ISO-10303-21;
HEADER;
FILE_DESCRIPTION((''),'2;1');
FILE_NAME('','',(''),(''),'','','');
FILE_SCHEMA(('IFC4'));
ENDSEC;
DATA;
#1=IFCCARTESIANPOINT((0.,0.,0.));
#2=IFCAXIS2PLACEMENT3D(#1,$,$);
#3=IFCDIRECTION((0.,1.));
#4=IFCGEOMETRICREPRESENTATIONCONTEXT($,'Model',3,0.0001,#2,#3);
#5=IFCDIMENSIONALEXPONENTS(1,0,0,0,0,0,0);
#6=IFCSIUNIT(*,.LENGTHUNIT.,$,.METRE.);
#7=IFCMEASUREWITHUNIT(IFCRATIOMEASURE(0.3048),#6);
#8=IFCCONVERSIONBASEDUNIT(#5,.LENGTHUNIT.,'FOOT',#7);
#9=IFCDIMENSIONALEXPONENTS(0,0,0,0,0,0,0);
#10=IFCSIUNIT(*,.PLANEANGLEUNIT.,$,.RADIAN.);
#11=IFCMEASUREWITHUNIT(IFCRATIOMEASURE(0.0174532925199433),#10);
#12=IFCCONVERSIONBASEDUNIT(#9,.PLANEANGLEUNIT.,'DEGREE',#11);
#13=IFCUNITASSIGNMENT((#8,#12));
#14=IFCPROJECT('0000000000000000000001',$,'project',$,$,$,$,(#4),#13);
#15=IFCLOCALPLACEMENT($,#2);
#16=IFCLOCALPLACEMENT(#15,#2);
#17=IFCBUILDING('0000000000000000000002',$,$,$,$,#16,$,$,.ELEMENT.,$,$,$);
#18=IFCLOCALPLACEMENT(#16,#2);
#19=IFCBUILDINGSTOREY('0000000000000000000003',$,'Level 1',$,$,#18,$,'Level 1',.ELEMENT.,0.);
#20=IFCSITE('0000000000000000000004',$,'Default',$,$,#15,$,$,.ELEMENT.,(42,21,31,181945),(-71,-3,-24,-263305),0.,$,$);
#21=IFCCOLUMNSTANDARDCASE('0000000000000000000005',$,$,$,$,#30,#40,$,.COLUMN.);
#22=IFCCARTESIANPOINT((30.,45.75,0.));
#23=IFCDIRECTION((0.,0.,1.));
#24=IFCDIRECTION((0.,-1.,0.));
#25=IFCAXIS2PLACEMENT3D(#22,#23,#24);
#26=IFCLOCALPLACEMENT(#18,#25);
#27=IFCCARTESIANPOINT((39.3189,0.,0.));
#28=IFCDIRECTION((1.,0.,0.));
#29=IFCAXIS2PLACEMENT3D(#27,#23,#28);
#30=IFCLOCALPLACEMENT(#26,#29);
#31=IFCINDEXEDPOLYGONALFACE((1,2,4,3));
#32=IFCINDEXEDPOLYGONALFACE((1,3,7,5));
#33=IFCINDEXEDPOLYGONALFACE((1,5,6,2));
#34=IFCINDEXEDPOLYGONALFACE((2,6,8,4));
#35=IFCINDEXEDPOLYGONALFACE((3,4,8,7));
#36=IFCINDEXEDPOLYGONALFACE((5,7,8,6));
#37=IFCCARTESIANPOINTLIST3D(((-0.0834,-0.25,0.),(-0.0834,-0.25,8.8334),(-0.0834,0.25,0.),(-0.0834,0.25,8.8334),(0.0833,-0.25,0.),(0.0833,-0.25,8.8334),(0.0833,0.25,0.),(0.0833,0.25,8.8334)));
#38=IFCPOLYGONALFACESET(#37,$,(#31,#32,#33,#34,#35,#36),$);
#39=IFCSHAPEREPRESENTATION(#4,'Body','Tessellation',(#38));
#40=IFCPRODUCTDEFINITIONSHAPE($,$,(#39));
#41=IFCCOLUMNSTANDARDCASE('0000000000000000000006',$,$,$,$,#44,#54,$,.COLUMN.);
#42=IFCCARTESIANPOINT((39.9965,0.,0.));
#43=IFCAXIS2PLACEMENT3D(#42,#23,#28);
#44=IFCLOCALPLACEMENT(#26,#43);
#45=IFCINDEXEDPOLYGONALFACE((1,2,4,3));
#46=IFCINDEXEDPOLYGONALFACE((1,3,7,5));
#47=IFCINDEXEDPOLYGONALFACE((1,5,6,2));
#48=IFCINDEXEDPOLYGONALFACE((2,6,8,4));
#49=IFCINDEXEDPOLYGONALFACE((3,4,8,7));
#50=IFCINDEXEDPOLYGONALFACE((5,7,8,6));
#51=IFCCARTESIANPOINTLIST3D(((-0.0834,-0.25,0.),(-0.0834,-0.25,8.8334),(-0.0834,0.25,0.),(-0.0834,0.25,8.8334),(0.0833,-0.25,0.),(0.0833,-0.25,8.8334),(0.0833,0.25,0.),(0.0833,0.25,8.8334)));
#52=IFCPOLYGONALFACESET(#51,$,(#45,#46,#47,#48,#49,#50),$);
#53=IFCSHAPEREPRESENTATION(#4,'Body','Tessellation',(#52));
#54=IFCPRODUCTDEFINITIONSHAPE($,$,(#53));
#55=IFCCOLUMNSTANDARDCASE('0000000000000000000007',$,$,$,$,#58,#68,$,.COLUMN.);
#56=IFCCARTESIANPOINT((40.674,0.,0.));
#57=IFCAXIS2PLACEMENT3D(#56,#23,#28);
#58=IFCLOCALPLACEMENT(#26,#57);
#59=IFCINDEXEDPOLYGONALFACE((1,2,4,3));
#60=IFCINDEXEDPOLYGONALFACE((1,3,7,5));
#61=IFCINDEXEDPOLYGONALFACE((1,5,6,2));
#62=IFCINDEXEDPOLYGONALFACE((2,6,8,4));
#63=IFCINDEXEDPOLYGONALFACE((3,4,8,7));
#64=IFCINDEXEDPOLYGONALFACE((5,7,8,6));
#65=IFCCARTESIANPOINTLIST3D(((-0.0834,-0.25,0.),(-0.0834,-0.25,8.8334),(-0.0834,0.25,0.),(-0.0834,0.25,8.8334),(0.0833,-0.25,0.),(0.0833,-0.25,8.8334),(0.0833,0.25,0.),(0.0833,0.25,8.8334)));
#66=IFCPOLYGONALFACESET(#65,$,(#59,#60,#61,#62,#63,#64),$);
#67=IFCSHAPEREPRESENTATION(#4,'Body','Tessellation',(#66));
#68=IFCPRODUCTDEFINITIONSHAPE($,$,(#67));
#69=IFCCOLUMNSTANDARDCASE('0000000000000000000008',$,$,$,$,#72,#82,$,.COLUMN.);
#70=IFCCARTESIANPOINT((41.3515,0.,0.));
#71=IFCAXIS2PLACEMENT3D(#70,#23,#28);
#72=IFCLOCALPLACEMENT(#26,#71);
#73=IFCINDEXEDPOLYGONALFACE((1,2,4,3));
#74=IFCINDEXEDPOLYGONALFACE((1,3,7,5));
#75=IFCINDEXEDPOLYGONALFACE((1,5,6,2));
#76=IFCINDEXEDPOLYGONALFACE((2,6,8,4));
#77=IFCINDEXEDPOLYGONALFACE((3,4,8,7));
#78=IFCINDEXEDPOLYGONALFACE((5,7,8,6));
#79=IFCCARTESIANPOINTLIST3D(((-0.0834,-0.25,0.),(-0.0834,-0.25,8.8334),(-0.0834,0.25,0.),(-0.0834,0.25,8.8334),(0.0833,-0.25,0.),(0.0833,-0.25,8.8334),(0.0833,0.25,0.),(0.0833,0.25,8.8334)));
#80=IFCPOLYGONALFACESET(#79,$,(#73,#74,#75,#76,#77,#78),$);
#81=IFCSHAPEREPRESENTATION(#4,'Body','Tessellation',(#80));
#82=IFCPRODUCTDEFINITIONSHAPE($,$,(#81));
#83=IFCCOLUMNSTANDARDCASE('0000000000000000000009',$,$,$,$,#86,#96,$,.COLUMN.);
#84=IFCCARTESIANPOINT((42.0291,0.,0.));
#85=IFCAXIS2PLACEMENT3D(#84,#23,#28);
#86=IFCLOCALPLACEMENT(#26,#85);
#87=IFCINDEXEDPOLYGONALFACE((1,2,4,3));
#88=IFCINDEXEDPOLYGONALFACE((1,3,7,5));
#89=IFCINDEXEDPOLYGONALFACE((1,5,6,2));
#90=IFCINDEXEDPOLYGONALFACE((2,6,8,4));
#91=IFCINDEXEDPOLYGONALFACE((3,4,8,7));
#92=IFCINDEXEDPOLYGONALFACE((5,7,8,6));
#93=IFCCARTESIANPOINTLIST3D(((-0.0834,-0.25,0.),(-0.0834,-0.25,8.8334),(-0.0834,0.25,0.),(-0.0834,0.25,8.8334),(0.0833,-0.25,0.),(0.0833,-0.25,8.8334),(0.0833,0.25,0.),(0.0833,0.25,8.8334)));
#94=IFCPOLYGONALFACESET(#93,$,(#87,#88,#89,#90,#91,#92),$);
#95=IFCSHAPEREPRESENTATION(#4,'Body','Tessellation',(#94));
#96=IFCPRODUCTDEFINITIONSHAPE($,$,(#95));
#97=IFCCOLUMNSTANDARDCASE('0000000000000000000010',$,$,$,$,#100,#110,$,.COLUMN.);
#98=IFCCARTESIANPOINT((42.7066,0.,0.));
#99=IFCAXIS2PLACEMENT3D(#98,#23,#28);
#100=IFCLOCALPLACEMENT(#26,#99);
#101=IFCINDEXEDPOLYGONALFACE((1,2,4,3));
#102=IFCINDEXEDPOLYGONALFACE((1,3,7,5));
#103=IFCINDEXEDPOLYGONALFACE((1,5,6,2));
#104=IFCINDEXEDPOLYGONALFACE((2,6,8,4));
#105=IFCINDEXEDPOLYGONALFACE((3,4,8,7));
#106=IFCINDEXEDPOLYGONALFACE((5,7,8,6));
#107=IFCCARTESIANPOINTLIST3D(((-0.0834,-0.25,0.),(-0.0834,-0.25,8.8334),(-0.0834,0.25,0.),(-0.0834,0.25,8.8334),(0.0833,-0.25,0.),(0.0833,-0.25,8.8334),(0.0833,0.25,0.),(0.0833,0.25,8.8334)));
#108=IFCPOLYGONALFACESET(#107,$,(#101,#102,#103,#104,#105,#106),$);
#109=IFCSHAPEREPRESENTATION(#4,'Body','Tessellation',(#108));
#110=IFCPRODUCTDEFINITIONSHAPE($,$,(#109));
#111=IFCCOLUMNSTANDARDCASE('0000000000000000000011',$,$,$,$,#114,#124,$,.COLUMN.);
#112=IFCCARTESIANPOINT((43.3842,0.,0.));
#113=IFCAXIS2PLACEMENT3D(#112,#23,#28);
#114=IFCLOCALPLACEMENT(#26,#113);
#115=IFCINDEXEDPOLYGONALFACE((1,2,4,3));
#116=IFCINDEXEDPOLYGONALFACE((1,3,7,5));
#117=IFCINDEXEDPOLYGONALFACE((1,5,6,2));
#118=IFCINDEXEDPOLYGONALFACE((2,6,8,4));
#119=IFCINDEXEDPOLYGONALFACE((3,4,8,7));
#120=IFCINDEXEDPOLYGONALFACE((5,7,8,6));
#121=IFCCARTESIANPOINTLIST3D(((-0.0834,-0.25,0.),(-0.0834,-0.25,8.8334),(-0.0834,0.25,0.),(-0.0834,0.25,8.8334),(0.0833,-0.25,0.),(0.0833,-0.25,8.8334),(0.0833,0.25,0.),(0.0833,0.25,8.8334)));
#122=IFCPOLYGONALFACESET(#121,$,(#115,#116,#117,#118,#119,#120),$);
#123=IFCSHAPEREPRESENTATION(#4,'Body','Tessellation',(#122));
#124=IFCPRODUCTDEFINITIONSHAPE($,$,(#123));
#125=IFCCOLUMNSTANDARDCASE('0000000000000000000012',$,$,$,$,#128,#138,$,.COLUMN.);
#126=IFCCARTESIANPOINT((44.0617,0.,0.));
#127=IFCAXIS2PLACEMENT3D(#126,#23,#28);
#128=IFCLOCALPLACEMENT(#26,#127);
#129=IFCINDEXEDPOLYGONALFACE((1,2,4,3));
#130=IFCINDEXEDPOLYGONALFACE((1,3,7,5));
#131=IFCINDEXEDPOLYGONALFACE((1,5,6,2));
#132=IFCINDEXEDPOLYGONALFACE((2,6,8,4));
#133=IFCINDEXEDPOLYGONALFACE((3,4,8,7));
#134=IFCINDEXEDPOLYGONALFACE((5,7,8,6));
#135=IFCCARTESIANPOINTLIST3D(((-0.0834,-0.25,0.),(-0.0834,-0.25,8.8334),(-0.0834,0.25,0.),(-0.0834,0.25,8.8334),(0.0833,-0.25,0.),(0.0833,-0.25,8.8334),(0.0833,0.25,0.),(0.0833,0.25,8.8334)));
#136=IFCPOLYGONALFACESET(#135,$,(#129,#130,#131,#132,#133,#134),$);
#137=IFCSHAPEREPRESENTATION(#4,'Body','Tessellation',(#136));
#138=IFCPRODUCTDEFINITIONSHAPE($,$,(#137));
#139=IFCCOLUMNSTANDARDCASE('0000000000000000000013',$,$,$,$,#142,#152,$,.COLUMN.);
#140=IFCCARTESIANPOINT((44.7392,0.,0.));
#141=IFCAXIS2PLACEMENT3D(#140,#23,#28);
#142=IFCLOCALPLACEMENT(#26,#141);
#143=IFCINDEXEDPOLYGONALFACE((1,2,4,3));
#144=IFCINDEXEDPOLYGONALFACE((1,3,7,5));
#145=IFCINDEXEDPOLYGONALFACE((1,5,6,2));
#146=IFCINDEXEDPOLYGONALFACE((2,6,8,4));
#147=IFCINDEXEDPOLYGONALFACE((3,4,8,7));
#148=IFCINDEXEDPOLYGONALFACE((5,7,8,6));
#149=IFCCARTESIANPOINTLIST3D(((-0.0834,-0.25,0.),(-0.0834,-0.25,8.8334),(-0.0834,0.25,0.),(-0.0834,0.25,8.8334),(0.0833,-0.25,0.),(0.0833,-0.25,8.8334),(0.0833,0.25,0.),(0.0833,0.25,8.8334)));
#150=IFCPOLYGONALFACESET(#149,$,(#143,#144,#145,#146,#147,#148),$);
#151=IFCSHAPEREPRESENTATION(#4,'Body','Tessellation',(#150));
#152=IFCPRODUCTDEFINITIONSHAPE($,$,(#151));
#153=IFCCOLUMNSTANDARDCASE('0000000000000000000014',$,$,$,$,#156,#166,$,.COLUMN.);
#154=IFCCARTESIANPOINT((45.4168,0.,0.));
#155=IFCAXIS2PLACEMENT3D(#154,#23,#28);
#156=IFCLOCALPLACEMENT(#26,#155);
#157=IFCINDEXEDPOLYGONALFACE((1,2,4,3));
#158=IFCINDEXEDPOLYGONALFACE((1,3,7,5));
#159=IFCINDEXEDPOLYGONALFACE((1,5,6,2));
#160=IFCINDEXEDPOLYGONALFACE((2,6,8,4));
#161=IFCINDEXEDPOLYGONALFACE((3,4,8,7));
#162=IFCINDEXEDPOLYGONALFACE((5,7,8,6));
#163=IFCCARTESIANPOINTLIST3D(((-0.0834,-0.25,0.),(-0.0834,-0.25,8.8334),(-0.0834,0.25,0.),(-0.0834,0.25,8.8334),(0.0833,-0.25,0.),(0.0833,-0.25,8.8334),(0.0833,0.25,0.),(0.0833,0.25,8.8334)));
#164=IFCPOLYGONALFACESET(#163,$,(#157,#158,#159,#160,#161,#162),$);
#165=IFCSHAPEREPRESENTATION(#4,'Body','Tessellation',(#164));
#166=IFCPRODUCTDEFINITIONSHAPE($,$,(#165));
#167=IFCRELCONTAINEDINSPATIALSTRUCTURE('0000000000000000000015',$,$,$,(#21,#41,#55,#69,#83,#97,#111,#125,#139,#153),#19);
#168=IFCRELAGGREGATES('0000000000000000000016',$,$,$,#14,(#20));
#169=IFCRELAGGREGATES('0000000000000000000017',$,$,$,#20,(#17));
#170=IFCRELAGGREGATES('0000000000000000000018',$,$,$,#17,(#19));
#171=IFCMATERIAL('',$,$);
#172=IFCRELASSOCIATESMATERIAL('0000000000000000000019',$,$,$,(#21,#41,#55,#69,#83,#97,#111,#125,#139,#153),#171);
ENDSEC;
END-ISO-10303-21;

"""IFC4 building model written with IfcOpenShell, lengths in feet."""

from ifc_helpers import new_model, entity, si_unit, converted_unit, direction, frame, origin, place, context, project, spatial, rectangle, extrude, material, element, save


model = new_model("IFC4")

# Units and contexts
model_context = context("Model", 3, precision=0.0001, world=origin(), true_north=direction((0.0, 1.0)))
ifc_project = project(units=[converted_unit("LENGTHUNIT", "FOOT", entity("IfcRatioMeasure", 0.3048), si_unit("LENGTHUNIT", "METRE"), dimensions=[1, 0, 0, 0, 0, 0, 0]), converted_unit("PLANEANGLEUNIT", "DEGREE", entity("IfcRatioMeasure", 0.0174532925199433), si_unit("PLANEANGLEUNIT", "RADIAN"), dimensions=[0, 0, 0, 0, 0, 0, 0])], contexts=[model_context])

# Site, building, storey
site_placement = place(None, origin())
site = spatial("IfcSite", under=ifc_project, at=site_placement, Name="Default", CompositionType="ELEMENT", RefLatitude=(42, 21, 31, 181945), RefLongitude=(-71, -3, -24, -263305), RefElevation=0.0)
building_placement = place(site_placement, origin())
building = spatial("IfcBuilding", under=site, at=building_placement, CompositionType="ELEMENT")
storey_placement = place(building_placement, origin())
storey = spatial("IfcBuildingStorey", under=building, at=storey_placement, Name="Level 1", LongName="Level 1", CompositionType="ELEMENT", Elevation=0.0)

# Columns
ifc_material_1 = material(Name="")
placement_1 = place(storey_placement, frame((30.0, 45.75, 0.0), z_axis=(0.0, 0.0, 1.0), x_axis=(0.0, -1.0, 0.0)))
for number, where, z_axis, x_axis in (
    (1, (39.3189, 0.0, 0.0), (0.0, 0.0, 1.0), (1.0, 0.0, 0.0)),
    (2, (39.9965, 0.0, 0.0), (0.0, 0.0, 1.0), (1.0, 0.0, 0.0)),
    (3, (40.674, 0.0, 0.0), (0.0, 0.0, 1.0), (1.0, 0.0, 0.0)),
    (4, (41.3515, 0.0, 0.0), (0.0, 0.0, 1.0), (1.0, 0.0, 0.0)),
    (5, (42.0291, 0.0, 0.0), (0.0, 0.0, 1.0), (1.0, 0.0, 0.0)),
    (6, (42.7066, 0.0, 0.0), (0.0, 0.0, 1.0), (1.0, 0.0, 0.0)),
    (7, (43.3842, 0.0, 0.0), (0.0, 0.0, 1.0), (1.0, 0.0, 0.0)),
    (8, (44.0617, 0.0, 0.0), (0.0, 0.0, 1.0), (1.0, 0.0, 0.0)),
    (9, (44.7392, 0.0, 0.0), (0.0, 0.0, 1.0), (1.0, 0.0, 0.0)),
    (10, (45.4168, 0.0, 0.0), (0.0, 0.0, 1.0), (1.0, 0.0, 0.0)),
):
    element("IfcColumnStandardCase", number, at=place(placement_1, frame(where, z_axis=z_axis, x_axis=x_axis)), inside=storey, material=ifc_material_1, PredefinedType="COLUMN", context=model_context, shape_type="SweptSolid", body=[
        extrude(rectangle(XDim=0.1667, YDim=0.5), origin(), (0.0, 0.0, 1.0), 8.8334),
    ])

save(model, "model.ifc")
